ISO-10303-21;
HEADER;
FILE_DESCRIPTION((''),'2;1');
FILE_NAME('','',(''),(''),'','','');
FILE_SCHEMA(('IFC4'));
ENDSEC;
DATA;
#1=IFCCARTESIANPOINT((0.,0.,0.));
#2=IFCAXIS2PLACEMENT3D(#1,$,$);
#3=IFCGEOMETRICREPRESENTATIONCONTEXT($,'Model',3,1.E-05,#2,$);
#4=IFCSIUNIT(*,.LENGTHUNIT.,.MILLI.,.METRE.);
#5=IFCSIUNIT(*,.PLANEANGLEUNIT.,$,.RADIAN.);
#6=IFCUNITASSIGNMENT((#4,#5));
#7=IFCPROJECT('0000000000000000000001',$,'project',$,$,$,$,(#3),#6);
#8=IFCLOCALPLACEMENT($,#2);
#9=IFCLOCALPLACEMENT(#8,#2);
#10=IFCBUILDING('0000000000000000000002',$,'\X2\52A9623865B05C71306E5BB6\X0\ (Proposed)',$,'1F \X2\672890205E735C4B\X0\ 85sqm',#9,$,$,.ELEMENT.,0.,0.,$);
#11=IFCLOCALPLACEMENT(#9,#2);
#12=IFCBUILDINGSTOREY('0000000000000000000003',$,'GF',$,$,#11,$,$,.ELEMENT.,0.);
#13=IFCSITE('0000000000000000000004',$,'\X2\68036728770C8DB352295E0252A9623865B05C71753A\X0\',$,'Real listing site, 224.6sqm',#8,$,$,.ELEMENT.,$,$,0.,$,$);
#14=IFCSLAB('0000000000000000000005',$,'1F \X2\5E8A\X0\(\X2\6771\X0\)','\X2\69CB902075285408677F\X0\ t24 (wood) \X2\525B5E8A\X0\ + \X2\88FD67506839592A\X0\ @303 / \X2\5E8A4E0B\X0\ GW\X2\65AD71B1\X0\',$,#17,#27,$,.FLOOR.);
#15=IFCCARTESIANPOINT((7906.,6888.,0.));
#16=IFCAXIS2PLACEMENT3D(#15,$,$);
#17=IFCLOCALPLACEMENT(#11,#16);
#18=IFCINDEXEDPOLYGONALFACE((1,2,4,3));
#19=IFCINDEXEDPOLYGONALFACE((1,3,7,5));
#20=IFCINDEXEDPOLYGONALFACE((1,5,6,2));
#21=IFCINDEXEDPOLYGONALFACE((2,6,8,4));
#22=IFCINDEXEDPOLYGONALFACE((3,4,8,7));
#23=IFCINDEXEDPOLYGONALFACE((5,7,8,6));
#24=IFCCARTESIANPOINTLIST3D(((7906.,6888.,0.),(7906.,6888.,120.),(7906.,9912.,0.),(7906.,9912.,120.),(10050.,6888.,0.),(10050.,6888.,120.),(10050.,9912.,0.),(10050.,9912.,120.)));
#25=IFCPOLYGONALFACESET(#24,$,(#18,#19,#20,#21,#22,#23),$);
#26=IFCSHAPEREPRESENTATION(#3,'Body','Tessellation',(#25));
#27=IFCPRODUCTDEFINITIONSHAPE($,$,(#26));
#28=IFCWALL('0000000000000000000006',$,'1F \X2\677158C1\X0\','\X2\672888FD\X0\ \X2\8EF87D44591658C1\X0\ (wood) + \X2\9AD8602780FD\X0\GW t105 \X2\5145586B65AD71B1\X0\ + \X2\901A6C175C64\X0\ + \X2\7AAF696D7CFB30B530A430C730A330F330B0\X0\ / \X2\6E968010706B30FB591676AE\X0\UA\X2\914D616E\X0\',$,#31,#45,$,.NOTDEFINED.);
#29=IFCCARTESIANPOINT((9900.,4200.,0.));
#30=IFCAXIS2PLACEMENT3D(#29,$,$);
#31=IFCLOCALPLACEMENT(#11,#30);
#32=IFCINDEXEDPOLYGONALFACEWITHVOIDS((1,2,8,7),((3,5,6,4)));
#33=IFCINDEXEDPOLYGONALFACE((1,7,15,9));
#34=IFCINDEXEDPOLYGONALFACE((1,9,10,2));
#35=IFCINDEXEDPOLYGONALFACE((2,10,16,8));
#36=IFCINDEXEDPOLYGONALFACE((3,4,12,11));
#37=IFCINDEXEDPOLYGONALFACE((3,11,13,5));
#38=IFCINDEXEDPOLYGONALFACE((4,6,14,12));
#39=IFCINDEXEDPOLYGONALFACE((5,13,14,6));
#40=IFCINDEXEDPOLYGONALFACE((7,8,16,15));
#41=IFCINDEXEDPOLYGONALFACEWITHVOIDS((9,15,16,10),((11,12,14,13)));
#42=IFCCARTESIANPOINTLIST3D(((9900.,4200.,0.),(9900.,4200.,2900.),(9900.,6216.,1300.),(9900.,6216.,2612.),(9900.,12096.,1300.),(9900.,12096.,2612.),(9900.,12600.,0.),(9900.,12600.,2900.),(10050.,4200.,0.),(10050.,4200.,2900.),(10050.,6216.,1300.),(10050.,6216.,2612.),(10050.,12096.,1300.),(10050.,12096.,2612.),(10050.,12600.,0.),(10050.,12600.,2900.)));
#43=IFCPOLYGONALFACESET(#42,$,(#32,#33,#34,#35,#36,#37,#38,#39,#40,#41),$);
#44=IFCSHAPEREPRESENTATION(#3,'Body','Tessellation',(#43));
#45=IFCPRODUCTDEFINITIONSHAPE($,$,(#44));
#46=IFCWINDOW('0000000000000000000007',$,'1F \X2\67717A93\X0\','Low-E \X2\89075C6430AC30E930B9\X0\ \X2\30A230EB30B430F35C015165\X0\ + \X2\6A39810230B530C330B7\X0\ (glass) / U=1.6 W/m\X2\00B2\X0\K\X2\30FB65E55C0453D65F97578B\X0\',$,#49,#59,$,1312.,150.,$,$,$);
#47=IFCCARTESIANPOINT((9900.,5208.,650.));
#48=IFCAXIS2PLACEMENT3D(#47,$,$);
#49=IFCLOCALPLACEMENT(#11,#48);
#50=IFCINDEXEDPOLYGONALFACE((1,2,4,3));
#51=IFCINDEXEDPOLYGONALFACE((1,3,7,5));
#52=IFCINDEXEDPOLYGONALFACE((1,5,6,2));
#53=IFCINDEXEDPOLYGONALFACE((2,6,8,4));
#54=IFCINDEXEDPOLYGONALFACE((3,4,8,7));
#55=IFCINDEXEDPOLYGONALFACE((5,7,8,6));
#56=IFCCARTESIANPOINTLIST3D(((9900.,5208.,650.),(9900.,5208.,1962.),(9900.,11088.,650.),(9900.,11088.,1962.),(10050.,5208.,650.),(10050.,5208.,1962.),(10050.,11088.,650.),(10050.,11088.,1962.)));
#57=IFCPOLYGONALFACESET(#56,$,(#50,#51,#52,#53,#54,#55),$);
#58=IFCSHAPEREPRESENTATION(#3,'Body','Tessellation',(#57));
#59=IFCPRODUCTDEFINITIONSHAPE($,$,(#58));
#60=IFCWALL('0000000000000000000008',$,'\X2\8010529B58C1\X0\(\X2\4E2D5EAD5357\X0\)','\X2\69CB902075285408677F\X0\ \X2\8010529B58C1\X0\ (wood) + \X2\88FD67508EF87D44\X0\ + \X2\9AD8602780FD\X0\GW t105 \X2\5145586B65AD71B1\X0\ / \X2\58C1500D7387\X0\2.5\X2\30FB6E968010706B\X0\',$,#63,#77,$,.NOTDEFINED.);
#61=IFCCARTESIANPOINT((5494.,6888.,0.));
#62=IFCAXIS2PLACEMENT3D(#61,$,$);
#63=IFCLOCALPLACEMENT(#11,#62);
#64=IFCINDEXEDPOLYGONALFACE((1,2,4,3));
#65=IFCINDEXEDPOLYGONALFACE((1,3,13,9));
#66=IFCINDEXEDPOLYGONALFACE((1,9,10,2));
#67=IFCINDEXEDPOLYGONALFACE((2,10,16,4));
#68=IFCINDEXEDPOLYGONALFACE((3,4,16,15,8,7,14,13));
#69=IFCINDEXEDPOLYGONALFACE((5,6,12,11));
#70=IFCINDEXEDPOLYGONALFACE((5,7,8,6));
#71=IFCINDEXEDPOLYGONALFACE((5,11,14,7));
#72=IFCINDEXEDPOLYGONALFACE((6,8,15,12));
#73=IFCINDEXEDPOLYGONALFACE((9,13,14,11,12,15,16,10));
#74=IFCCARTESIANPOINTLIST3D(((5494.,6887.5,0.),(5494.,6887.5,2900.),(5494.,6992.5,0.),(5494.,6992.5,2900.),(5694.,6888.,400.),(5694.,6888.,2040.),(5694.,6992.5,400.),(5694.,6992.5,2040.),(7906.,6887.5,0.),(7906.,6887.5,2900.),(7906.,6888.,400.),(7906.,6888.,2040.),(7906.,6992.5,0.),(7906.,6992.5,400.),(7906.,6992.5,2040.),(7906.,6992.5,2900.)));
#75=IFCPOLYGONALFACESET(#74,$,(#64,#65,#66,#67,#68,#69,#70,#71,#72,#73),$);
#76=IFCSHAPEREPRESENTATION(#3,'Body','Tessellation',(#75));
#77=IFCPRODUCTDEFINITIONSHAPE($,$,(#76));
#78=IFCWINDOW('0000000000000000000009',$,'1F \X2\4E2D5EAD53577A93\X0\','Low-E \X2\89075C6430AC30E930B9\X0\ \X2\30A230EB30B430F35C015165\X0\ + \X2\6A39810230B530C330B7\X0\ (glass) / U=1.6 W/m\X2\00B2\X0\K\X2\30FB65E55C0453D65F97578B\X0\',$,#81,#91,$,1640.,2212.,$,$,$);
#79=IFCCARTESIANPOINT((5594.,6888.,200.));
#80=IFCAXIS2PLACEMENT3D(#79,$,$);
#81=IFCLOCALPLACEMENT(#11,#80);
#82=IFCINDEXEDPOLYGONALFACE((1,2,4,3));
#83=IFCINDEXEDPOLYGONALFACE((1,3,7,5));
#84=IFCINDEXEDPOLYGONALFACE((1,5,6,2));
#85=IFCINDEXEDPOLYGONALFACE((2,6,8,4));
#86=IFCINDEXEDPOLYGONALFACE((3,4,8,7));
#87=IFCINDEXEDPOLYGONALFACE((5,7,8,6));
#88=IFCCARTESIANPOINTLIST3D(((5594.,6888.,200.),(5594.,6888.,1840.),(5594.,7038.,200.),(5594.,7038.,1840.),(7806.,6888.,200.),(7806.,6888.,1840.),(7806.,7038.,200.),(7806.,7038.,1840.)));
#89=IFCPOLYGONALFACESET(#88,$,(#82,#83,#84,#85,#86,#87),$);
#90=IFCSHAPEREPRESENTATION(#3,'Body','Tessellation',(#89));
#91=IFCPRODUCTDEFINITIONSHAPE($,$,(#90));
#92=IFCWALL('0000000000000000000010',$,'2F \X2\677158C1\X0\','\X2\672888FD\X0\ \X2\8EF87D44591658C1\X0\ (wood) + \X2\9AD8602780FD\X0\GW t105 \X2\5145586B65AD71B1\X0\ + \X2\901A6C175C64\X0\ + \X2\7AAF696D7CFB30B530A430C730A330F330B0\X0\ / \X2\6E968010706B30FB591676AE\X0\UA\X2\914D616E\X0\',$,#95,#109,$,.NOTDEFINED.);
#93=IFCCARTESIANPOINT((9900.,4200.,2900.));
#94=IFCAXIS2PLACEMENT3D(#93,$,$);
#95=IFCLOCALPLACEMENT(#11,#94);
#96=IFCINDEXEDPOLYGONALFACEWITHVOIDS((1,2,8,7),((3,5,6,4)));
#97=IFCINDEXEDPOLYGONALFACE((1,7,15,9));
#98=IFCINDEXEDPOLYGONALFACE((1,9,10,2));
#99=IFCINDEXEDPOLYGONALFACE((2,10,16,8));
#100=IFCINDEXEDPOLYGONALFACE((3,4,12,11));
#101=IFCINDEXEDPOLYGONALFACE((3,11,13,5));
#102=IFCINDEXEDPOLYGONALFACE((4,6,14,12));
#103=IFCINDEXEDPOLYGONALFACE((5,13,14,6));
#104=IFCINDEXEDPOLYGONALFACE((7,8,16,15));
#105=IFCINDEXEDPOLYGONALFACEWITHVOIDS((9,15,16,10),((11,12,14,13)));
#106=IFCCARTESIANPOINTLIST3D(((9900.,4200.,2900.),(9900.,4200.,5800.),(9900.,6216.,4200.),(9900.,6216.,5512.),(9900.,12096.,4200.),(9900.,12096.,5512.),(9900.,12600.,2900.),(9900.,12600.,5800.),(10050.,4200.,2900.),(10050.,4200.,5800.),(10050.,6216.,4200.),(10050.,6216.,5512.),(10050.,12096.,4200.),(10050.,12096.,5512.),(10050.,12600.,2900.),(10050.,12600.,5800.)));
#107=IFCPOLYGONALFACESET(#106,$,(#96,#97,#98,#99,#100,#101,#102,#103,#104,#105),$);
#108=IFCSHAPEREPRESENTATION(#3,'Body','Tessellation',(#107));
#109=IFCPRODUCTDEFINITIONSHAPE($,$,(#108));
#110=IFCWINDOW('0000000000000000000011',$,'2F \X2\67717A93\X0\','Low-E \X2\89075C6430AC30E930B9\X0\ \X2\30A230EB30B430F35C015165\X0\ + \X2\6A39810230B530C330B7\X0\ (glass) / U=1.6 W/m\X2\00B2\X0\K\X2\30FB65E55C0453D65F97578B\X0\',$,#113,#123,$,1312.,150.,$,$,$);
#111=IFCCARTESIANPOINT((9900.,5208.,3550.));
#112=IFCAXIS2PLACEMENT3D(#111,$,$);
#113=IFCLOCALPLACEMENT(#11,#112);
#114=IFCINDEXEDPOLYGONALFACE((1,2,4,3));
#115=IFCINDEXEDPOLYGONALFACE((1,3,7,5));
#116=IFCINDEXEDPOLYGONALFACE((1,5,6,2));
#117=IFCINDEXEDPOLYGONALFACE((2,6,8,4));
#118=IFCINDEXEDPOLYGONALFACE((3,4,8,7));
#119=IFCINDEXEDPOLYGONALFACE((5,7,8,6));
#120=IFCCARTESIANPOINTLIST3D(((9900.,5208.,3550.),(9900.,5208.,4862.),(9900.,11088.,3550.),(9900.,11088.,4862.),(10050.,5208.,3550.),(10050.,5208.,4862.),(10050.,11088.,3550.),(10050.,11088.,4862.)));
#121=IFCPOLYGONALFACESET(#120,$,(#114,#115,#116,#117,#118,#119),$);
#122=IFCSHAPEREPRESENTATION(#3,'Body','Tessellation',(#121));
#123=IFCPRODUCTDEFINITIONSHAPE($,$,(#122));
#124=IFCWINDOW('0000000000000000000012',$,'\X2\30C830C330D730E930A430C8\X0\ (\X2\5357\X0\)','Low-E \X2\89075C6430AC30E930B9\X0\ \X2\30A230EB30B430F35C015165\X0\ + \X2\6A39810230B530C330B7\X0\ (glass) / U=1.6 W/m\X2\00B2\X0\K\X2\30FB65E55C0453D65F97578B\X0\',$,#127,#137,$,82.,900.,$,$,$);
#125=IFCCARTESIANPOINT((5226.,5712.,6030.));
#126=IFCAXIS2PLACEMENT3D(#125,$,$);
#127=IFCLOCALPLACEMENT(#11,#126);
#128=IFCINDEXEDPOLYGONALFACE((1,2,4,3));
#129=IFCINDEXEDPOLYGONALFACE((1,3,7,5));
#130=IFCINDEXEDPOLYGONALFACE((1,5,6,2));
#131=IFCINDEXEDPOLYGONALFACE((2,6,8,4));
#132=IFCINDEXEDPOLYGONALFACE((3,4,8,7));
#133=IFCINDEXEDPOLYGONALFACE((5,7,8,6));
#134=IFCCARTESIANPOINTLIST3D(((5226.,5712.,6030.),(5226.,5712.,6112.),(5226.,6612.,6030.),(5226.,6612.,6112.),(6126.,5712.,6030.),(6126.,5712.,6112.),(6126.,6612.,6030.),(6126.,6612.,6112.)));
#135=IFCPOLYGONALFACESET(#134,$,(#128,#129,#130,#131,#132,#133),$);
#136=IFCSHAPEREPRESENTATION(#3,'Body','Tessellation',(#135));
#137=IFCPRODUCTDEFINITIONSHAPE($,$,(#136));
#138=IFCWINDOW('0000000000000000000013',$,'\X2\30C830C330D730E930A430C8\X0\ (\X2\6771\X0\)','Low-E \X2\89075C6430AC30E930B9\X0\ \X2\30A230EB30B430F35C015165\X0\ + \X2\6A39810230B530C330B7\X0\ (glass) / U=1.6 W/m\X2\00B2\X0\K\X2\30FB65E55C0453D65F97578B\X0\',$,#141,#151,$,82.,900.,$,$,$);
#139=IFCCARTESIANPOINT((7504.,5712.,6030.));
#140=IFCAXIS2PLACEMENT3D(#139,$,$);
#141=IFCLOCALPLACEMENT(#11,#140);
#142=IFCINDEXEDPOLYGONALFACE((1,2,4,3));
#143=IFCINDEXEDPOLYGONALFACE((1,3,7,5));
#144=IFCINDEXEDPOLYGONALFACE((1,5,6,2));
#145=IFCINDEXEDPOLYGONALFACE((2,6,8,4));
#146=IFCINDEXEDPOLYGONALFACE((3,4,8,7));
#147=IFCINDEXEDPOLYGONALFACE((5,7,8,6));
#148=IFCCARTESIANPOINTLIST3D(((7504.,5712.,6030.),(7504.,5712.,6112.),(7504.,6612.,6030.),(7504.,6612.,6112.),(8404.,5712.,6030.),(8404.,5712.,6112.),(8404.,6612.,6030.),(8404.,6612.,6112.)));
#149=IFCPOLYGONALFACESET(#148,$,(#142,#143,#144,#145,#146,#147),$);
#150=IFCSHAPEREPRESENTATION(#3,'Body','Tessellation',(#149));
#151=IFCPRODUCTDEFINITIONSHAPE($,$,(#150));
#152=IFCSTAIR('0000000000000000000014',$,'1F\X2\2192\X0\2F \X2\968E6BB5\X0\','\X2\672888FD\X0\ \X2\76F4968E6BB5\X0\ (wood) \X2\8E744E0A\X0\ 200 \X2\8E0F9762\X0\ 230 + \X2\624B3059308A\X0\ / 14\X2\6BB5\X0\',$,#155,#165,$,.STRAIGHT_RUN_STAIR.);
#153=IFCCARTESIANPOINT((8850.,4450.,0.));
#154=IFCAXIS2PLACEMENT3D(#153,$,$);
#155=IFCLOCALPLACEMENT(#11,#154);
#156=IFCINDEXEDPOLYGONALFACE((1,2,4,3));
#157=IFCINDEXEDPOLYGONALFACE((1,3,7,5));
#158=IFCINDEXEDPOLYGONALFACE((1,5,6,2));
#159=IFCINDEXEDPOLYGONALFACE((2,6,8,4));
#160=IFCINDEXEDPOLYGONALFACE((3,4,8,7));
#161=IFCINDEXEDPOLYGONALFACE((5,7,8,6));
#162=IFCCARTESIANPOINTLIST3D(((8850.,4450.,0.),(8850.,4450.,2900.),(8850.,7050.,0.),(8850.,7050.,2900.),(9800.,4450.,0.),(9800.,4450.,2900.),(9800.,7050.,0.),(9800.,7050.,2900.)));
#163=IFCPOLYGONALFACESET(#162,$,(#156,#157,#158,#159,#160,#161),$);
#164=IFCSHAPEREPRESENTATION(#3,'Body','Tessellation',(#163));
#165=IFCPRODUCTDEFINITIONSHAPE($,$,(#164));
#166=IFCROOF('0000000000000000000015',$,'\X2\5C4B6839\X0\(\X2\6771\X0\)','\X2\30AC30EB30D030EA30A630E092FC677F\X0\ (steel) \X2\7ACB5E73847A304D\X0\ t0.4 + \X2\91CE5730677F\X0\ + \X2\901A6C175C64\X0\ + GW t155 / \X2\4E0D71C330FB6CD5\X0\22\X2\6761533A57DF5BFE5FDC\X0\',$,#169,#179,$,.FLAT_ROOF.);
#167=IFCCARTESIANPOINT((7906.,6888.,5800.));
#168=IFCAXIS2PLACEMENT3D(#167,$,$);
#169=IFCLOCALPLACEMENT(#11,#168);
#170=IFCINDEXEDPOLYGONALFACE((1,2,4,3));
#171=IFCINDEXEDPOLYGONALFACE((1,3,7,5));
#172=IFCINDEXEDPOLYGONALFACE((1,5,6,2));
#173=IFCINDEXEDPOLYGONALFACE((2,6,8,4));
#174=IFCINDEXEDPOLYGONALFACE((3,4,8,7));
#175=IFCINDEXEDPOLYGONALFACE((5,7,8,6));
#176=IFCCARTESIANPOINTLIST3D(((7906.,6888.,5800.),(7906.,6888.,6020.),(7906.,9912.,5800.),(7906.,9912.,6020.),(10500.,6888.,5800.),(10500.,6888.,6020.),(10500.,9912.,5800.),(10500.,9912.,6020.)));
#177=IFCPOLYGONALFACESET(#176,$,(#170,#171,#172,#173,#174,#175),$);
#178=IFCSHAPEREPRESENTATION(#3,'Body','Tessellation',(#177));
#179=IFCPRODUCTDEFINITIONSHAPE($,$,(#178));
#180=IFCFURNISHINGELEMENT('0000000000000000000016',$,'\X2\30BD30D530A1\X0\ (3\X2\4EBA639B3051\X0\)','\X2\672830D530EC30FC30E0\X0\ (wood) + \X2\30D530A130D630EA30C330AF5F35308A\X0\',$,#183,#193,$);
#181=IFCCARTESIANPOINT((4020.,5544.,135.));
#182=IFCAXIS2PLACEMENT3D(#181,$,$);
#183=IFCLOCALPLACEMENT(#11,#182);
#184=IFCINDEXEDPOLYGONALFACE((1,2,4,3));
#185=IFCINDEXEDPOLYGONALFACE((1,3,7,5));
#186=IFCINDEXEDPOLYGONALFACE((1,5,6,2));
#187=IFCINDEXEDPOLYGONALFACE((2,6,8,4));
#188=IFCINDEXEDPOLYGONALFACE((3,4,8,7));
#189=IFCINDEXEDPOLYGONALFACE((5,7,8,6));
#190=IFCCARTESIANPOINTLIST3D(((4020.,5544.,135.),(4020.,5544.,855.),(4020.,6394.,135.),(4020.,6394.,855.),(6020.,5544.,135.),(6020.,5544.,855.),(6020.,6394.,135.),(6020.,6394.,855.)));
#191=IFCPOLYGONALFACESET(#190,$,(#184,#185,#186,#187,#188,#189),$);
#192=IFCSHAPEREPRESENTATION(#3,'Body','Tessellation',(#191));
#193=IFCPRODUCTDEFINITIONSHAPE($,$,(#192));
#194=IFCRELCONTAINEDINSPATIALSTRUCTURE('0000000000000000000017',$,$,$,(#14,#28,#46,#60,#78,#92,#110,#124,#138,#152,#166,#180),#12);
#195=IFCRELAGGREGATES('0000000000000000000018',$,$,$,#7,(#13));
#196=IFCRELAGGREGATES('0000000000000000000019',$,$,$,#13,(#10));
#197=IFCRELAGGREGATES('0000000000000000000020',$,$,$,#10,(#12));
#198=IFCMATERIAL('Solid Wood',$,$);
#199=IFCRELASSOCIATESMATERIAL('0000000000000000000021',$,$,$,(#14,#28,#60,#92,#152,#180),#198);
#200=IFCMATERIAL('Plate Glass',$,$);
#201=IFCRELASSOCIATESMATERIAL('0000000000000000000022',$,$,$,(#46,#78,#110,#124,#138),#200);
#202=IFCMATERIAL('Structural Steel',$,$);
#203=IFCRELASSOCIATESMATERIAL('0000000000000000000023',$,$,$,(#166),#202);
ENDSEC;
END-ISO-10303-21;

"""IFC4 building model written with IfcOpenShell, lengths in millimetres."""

from ifc_helpers import new_model, si_unit, frame, frame_2d, origin, place, context, project, spatial, rectangle, extrude, material, element, fill, save


model = new_model("IFC4")

# Units and contexts
model_context = context("Model", 3, precision=1e-05, world=origin())
ifc_project = project(units=[si_unit("LENGTHUNIT", "METRE", prefix="MILLI"), si_unit("PLANEANGLEUNIT", "RADIAN")], contexts=[model_context])

# Site, building, storey
site_placement = place(None, origin())
site = spatial("IfcSite", under=ifc_project, at=site_placement, Name="栃木県足利市助戸新山町", ObjectType="Real listing site, 224.6sqm", CompositionType="ELEMENT", RefElevation=0.0)
building_placement = place(site_placement, origin())
building = spatial("IfcBuilding", under=site, at=building_placement, Name="助戸新山の家 (Proposed)", ObjectType="1F 木造平屋 85sqm", CompositionType="ELEMENT", ElevationOfRefHeight=0.0, ElevationOfTerrain=0.0)
storey_placement = place(building_placement, origin())
storey = spatial("IfcBuildingStorey", under=building, at=storey_placement, Name="GF", CompositionType="ELEMENT", Elevation=0.0)

# Slab
ifc_material_1 = material(Name="Solid Wood")
slab_placement = place(storey_placement, frame((7906.0, 6888.0, 0.0)))
element("IfcSlab", 1, at=slab_placement, inside=storey, material=ifc_material_1, Name="1F 床(東)", Description="構造用合板 t24 (wood) 剛床 + 製材根太 @303 / 床下 GW断熱", PredefinedType="FLOOR", context=model_context, shape_type="SweptSolid", body=[
    extrude(rectangle(XDim=2144.0, YDim=3024.0, at=frame_2d((1072.0, 1512.0))), frame((7906.0, 6888.0, 0.0)), (0.0, 0.0, 1.0), 120.0),
])

# Walls, openings, windows
wall_1_placement = place(storey_placement, frame((9900.0, 4200.0, 0.0)))
wall_1 = element("IfcWall", 2, at=wall_1_placement, inside=storey, material=ifc_material_1, Name="1F 東壁", Description="木製 軸組外壁 (wood) + 高性能GW t105 充填断熱 + 通気層 + 窯業系サイディング / 準耐火・外皮UA配慮", PredefinedType="NOTDEFINED", context=model_context, shape_type="SweptSolid", body=[
    extrude(rectangle(XDim=150.0, YDim=8400.0, at=frame_2d((75.0, 4200.0))), frame((9900.0, 4200.0, 0.0)), (0.0, 0.0, 1.0), 2900.0),
])
opening_1_placement = place(storey_placement, frame((9900.0, 5208.0, 650.0)))
opening_1 = element("IfcOpeningElement", 3, at=opening_1_placement, cuts=wall_1, PredefinedType="NOTDEFINED", context=model_context, shape_type="SweptSolid", body=[
    extrude(rectangle(XDim=150.0, YDim=5880.0, at=frame_2d((75.0, 2940.0))), frame((9900.0, 5208.0, 650.0)), (0.0, 0.0, 1.0), 1312.0),
])
ifc_material_2 = material(Name="Plate Glass")
window_1_placement = place(storey_placement, frame((9900.0, 5208.0, 650.0)))
window_1 = element("IfcWindow", 4, at=window_1_placement, inside=storey, material=ifc_material_2, Name="1F 東窓", Description="Low-E 複層ガラス アルゴン封入 + 樹脂サッシ (glass) / U=1.6 W/m²K・日射取得型", OverallHeight=1312.0, OverallWidth=150.0, context=model_context, shape_type="SweptSolid", body=[
    extrude(rectangle(XDim=150.0, YDim=5880.0, at=frame_2d((75.0, 2940.0))), frame((9900.0, 5208.0, 650.0)), (0.0, 0.0, 1.0), 1312.0),
])
fill(opening_1, window_1)
wall_2_placement = place(storey_placement, frame((5494.0, 6888.0, 0.0)))
wall_2 = element("IfcWall", 5, at=wall_2_placement, inside=storey, material=ifc_material_1, Name="耐力壁(中庭南)", Description="構造用合板 耐力壁 (wood) + 製材軸組 + 高性能GW t105 充填断熱 / 壁倍率2.5・準耐火", PredefinedType="NOTDEFINED", context=model_context, shape_type="SweptSolid", body=[
    extrude(rectangle(XDim=2412.0, YDim=105.0, at=frame_2d((1206.0, 52.0))), frame((5494.0, 6888.0, 0.0)), (0.0, 0.0, 1.0), 2900.0),
])
opening_2_placement = place(storey_placement, frame((5594.0, 6888.0, 200.0)))
opening_2 = element("IfcOpeningElement", 6, at=opening_2_placement, cuts=wall_2, PredefinedType="NOTDEFINED", context=model_context, shape_type="SweptSolid", body=[
    extrude(rectangle(XDim=2212.0, YDim=150.0, at=frame_2d((1106.0, 75.0))), frame((5594.0, 6888.0, 200.0)), (0.0, 0.0, 1.0), 1640.0),
])
window_2_placement = place(storey_placement, frame((5594.0, 6888.0, 200.0)))
window_2 = element("IfcWindow", 7, at=window_2_placement, inside=storey, material=ifc_material_2, Name="1F 中庭南窓", Description="Low-E 複層ガラス アルゴン封入 + 樹脂サッシ (glass) / U=1.6 W/m²K・日射取得型", OverallHeight=1640.0, OverallWidth=2212.0, context=model_context, shape_type="SweptSolid", body=[
    extrude(rectangle(XDim=2212.0, YDim=150.0, at=frame_2d((1106.0, 75.0))), frame((5594.0, 6888.0, 200.0)), (0.0, 0.0, 1.0), 1640.0),
])
fill(opening_2, window_2)

# Wall, opening, window
wall_3_placement = place(storey_placement, frame((9900.0, 4200.0, 2900.0)))
wall_3 = element("IfcWall", 8, at=wall_3_placement, inside=storey, material=ifc_material_1, Name="2F 東壁", Description="木製 軸組外壁 (wood) + 高性能GW t105 充填断熱 + 通気層 + 窯業系サイディング / 準耐火・外皮UA配慮", PredefinedType="NOTDEFINED", context=model_context, shape_type="SweptSolid", body=[
    extrude(rectangle(XDim=150.0, YDim=8400.0, at=frame_2d((75.0, 4200.0))), frame((9900.0, 4200.0, 2900.0)), (0.0, 0.0, 1.0), 2900.0),
])
opening_3_placement = place(storey_placement, frame((9900.0, 5208.0, 3550.0)))
opening_3 = element("IfcOpeningElement", 9, at=opening_3_placement, cuts=wall_3, PredefinedType="NOTDEFINED", context=model_context, shape_type="SweptSolid", body=[
    extrude(rectangle(XDim=150.0, YDim=5880.0, at=frame_2d((75.0, 2940.0))), frame((9900.0, 5208.0, 3550.0)), (0.0, 0.0, 1.0), 1312.0),
])
window_3_placement = place(storey_placement, frame((9900.0, 5208.0, 3550.0)))
window_3 = element("IfcWindow", 10, at=window_3_placement, inside=storey, material=ifc_material_2, Name="2F 東窓", Description="Low-E 複層ガラス アルゴン封入 + 樹脂サッシ (glass) / U=1.6 W/m²K・日射取得型", OverallHeight=1312.0, OverallWidth=150.0, context=model_context, shape_type="SweptSolid", body=[
    extrude(rectangle(XDim=150.0, YDim=5880.0, at=frame_2d((75.0, 2940.0))), frame((9900.0, 5208.0, 3550.0)), (0.0, 0.0, 1.0), 1312.0),
])
fill(opening_3, window_3)

# Windows
window_4_placement = place(storey_placement, frame((5226.0, 5712.0, 6030.0)))
element("IfcWindow", 11, at=window_4_placement, inside=storey, material=ifc_material_2, Name="トップライト (南)", Description="Low-E 複層ガラス アルゴン封入 + 樹脂サッシ (glass) / U=1.6 W/m²K・日射取得型", OverallHeight=82.0, OverallWidth=900.0, context=model_context, shape_type="SweptSolid", body=[
    extrude(rectangle(XDim=900.0, YDim=900.0, at=frame_2d((450.0, 450.0))), frame((5226.0, 5712.0, 6030.0)), (0.0, 0.0, 1.0), 82.0),
])
window_5_placement = place(storey_placement, frame((7504.0, 5712.0, 6030.0)))
element("IfcWindow", 12, at=window_5_placement, inside=storey, material=ifc_material_2, Name="トップライト (東)", Description="Low-E 複層ガラス アルゴン封入 + 樹脂サッシ (glass) / U=1.6 W/m²K・日射取得型", OverallHeight=82.0, OverallWidth=900.0, context=model_context, shape_type="SweptSolid", body=[
    extrude(rectangle(XDim=900.0, YDim=900.0, at=frame_2d((450.0, 450.0))), frame((7504.0, 5712.0, 6030.0)), (0.0, 0.0, 1.0), 82.0),
])

# Stair
stair_placement = place(storey_placement, frame((8850.0, 4450.0, 0.0)))
element("IfcStair", 13, at=stair_placement, inside=storey, material=ifc_material_1, Name="1F→2F 階段", Description="木製 直階段 (wood) 蹴上 200 踏面 230 + 手すり / 14段", PredefinedType="STRAIGHT_RUN_STAIR", context=model_context, shape_type="SweptSolid", body=[
    extrude(rectangle(XDim=950.0, YDim=2600.0, at=frame_2d((475.0, 1300.0))), frame((8850.0, 4450.0, 0.0)), (0.0, 0.0, 1.0), 2900.0),
])

# Roof
ifc_material_3 = material(Name="Structural Steel")
roof_placement = place(storey_placement, frame((7906.0, 6888.0, 5800.0)))
element("IfcRoof", 14, at=roof_placement, inside=storey, material=ifc_material_3, Name="屋根(東)", Description="ガルバリウム鋼板 (steel) 立平葺き t0.4 + 野地板 + 通気層 + GW t155 / 不燃・法22条区域対応", PredefinedType="FLAT_ROOF", context=model_context, shape_type="SweptSolid", body=[
    extrude(rectangle(XDim=2594.0, YDim=3024.0, at=frame_2d((1297.0, 1512.0))), frame((7906.0, 6888.0, 5800.0)), (0.0, 0.0, 1.0), 220.0),
])

# Furnishing element
furnishing_1_placement = place(storey_placement, frame((4020.0, 5544.0, 135.0)))
element("IfcFurnishingElement", 15, at=furnishing_1_placement, inside=storey, material=ifc_material_1, Name="ソファ (3人掛け)", Description="木フレーム (wood) + ファブリック張り", context=model_context, shape_type="SweptSolid", body=[
    extrude(rectangle(XDim=2000.0, YDim=850.0, at=frame_2d((1000.0, 425.0))), frame((4020.0, 5544.0, 135.0)), (0.0, 0.0, 1.0), 720.0),
])

save(model, "model.ifc")
